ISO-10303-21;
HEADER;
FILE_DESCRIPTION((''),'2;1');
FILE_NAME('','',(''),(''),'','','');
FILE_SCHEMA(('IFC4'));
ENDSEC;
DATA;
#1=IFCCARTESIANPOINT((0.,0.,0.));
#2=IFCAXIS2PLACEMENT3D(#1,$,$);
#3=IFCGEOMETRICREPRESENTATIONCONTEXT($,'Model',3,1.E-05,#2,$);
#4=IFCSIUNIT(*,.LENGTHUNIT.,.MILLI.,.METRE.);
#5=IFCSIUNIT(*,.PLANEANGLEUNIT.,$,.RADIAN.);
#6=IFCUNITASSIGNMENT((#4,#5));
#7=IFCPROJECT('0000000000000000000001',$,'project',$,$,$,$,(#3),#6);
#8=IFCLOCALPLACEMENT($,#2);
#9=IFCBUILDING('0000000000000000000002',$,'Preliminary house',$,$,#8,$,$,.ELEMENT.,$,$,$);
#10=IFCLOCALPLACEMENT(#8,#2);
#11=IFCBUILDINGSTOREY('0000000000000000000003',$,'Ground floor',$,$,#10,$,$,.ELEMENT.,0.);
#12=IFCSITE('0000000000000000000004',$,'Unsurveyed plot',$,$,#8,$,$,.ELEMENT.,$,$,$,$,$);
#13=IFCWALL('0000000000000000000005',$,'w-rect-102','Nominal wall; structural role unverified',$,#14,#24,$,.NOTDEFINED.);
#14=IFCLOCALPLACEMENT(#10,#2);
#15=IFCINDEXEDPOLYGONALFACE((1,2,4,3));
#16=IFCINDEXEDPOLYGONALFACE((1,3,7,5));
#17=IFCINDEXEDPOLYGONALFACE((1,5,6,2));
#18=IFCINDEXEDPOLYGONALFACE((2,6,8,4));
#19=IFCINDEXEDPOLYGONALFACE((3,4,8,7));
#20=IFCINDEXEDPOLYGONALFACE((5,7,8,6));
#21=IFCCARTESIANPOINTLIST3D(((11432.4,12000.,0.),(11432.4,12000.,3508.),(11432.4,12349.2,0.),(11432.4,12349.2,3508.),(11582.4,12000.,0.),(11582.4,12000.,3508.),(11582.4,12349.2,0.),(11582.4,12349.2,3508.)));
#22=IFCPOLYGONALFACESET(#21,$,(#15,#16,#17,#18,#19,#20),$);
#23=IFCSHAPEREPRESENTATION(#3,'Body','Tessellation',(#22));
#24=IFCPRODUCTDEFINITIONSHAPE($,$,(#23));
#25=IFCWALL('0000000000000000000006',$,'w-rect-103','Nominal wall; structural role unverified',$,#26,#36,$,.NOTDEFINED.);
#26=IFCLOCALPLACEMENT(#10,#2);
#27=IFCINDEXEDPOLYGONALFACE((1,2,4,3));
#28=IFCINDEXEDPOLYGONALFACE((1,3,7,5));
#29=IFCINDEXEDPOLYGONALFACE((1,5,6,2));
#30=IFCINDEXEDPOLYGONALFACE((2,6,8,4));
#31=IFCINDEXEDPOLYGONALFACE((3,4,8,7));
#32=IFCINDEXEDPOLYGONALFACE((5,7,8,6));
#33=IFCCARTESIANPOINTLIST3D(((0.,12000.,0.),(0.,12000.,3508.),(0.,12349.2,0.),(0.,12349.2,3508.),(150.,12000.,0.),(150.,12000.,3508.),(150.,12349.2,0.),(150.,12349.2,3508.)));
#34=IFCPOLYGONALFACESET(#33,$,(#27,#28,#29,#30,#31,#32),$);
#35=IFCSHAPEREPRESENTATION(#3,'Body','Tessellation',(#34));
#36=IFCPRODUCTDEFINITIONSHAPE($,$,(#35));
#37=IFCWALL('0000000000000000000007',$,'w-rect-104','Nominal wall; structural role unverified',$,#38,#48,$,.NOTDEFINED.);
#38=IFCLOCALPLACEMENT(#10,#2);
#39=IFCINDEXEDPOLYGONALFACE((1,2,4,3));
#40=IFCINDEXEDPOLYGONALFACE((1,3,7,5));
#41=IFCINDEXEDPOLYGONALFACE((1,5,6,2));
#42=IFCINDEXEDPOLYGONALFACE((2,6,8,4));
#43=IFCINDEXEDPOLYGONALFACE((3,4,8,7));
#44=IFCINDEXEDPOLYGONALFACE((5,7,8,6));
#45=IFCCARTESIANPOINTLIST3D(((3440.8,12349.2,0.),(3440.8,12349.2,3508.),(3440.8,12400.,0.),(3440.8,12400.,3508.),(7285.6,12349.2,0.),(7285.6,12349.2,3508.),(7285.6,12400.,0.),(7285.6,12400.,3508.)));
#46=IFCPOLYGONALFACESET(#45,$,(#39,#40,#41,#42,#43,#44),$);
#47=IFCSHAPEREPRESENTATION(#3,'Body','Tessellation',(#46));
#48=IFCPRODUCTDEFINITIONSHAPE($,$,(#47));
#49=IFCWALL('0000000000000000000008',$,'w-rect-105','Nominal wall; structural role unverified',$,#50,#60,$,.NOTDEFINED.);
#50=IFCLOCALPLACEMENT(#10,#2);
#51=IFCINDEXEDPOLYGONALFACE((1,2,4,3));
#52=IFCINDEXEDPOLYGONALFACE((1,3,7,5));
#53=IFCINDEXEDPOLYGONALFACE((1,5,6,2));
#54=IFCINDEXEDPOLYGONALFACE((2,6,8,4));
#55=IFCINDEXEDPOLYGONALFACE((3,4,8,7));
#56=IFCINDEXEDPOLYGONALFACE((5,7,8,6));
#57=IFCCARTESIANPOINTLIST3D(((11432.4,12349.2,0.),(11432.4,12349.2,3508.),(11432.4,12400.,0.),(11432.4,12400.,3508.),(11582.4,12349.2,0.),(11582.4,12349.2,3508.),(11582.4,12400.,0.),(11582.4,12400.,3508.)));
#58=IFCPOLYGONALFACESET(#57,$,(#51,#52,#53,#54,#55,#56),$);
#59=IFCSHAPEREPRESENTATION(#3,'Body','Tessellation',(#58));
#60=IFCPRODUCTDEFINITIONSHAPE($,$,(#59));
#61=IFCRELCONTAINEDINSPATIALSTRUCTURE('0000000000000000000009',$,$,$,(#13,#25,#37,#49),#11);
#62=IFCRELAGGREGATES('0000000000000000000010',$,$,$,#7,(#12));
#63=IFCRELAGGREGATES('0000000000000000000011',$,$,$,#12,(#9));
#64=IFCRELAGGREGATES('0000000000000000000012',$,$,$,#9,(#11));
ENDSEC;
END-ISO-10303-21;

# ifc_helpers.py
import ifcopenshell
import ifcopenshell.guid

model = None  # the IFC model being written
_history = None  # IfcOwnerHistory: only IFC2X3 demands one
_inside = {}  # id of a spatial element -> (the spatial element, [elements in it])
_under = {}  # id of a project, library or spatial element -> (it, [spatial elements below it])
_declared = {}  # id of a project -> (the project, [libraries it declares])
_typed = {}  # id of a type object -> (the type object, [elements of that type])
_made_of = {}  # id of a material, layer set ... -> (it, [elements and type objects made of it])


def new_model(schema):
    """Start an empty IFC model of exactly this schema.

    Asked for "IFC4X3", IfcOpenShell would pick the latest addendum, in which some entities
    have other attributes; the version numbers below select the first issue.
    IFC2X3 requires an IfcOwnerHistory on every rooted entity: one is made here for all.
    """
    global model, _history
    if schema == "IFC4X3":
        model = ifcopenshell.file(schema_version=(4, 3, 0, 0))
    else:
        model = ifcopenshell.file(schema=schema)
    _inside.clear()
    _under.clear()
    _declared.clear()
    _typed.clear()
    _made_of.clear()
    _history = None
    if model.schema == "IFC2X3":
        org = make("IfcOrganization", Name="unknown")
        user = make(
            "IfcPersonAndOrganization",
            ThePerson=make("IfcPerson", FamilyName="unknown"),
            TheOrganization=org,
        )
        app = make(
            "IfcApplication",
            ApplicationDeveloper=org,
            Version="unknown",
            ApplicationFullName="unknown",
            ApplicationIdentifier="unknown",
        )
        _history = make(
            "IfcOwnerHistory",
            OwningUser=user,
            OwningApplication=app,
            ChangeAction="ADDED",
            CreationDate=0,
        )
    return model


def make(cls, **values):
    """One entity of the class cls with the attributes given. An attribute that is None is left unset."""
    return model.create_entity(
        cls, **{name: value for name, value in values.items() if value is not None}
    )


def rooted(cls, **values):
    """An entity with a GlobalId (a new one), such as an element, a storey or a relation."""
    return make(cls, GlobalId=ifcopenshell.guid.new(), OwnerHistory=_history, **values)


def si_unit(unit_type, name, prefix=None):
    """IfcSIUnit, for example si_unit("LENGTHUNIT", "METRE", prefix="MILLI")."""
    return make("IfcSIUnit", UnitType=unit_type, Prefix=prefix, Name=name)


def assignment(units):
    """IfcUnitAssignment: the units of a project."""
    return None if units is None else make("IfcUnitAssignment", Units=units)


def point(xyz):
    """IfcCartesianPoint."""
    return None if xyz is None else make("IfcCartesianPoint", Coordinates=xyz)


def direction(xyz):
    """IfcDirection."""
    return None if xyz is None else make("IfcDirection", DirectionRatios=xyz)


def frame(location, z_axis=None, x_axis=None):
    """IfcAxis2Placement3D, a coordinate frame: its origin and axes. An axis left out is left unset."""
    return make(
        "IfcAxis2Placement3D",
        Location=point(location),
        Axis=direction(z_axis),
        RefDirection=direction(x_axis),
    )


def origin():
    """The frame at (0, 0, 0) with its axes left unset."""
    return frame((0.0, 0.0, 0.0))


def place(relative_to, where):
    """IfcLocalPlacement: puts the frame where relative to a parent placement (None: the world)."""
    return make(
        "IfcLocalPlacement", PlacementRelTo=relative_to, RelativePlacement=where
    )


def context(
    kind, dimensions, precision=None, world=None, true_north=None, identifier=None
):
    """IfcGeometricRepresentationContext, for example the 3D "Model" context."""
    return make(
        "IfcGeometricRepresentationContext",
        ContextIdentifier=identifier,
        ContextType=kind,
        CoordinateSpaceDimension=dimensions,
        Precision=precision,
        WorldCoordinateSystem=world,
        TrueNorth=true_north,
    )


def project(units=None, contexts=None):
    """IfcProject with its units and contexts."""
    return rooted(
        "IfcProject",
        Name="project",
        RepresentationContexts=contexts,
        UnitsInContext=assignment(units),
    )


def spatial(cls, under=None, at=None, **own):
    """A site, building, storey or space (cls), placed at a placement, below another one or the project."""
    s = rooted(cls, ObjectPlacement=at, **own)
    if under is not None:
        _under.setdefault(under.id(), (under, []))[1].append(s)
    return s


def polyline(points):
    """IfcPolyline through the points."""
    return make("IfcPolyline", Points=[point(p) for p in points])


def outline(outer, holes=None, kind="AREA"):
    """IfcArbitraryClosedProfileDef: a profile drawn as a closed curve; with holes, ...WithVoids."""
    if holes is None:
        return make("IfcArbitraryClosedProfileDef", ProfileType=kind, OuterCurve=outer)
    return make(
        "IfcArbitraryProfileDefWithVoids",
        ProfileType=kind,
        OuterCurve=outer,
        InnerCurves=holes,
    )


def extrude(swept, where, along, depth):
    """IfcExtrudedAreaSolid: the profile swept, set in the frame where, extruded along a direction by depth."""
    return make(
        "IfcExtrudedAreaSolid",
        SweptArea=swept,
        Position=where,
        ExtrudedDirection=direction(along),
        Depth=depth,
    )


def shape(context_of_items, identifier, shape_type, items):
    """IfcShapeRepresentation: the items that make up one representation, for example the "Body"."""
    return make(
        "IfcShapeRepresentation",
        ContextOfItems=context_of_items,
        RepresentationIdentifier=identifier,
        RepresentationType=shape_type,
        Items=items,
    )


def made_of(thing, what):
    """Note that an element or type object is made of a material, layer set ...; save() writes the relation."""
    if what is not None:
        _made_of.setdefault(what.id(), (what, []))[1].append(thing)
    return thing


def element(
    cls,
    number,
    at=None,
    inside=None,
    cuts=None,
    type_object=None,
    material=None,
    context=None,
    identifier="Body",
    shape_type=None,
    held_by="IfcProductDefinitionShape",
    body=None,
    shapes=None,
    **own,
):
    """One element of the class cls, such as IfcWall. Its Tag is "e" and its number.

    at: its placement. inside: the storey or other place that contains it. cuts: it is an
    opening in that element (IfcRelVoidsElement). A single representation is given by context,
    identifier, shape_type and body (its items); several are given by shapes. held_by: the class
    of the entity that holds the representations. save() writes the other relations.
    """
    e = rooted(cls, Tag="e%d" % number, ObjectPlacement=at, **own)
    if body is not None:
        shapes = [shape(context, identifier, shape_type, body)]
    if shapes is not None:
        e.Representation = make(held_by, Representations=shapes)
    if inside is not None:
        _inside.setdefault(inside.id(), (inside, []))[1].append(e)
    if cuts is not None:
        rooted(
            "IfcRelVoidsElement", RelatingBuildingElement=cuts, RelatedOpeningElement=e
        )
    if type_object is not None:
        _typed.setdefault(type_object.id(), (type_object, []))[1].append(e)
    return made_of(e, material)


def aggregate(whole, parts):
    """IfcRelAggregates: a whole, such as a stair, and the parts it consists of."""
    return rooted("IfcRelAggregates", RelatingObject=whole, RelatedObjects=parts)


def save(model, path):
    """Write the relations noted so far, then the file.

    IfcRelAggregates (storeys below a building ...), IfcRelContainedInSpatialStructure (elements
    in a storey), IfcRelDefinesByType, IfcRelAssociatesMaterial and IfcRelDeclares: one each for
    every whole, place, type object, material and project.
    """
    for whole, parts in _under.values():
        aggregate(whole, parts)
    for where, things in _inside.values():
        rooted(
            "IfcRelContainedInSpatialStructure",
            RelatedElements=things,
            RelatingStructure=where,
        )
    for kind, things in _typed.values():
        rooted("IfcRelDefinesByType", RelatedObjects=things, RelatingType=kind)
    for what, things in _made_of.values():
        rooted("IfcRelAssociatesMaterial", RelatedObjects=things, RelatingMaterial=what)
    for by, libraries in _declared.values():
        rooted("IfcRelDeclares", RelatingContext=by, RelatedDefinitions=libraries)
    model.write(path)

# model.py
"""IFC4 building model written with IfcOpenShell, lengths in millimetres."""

from ifc_helpers import new_model, si_unit, origin, place, context, project, spatial, polyline, outline, extrude, element, save


model = new_model("IFC4")

# Units and contexts
model_context = context("Model", 3, precision=1e-05, world=origin())
ifc_project = project(units=[si_unit("LENGTHUNIT", "METRE", prefix="MILLI"), si_unit("PLANEANGLEUNIT", "RADIAN")], contexts=[model_context])

# Site, building, storey
placement_1 = place(None, origin())
site = spatial("IfcSite", under=ifc_project, at=placement_1, Name="Unsurveyed plot", CompositionType="ELEMENT")
building = spatial("IfcBuilding", under=site, at=placement_1, Name="Preliminary house", CompositionType="ELEMENT")
placement_2 = place(placement_1, origin())
storey = spatial("IfcBuildingStorey", under=building, at=placement_2, Name="Ground floor", CompositionType="ELEMENT", Elevation=0.0)

# Walls
element("IfcWall", 1, at=placement_2, inside=storey, Name="w-rect-102", Description="Nominal wall; structural role unverified", PredefinedType="NOTDEFINED", context=model_context, shape_type="SweptSolid", body=[
    extrude(outline(polyline([(11432.4, 12000.0), (11582.4, 12000.0), (11582.4, 12349.2), (11432.4, 12349.2), (11432.4, 12000.0)])), origin(), (0.0, 0.0, 1.0), 3508.0),
])
element("IfcWall", 2, at=placement_2, inside=storey, Name="w-rect-103", Description="Nominal wall; structural role unverified", PredefinedType="NOTDEFINED", context=model_context, shape_type="SweptSolid", body=[
    extrude(outline(polyline([(0.0, 12000.0), (150.0, 12000.0), (150.0, 12349.2), (0.0, 12349.2), (0.0, 12000.0)])), origin(), (0.0, 0.0, 1.0), 3508.0),
])
element("IfcWall", 3, at=placement_2, inside=storey, Name="w-rect-104", Description="Nominal wall; structural role unverified", PredefinedType="NOTDEFINED", context=model_context, shape_type="SweptSolid", body=[
    extrude(outline(polyline([(3440.8, 12349.2), (7285.6, 12349.2), (7285.6, 12400.0), (3440.8, 12400.0), (3440.8, 12349.2)])), origin(), (0.0, 0.0, 1.0), 3508.0),
])
element("IfcWall", 4, at=placement_2, inside=storey, Name="w-rect-105", Description="Nominal wall; structural role unverified", PredefinedType="NOTDEFINED", context=model_context, shape_type="SweptSolid", body=[
    extrude(outline(polyline([(11432.4, 12349.2), (11582.4, 12349.2), (11582.4, 12400.0), (11432.4, 12400.0), (11432.4, 12349.2)])), origin(), (0.0, 0.0, 1.0), 3508.0),
])

save(model, "model.ifc")
